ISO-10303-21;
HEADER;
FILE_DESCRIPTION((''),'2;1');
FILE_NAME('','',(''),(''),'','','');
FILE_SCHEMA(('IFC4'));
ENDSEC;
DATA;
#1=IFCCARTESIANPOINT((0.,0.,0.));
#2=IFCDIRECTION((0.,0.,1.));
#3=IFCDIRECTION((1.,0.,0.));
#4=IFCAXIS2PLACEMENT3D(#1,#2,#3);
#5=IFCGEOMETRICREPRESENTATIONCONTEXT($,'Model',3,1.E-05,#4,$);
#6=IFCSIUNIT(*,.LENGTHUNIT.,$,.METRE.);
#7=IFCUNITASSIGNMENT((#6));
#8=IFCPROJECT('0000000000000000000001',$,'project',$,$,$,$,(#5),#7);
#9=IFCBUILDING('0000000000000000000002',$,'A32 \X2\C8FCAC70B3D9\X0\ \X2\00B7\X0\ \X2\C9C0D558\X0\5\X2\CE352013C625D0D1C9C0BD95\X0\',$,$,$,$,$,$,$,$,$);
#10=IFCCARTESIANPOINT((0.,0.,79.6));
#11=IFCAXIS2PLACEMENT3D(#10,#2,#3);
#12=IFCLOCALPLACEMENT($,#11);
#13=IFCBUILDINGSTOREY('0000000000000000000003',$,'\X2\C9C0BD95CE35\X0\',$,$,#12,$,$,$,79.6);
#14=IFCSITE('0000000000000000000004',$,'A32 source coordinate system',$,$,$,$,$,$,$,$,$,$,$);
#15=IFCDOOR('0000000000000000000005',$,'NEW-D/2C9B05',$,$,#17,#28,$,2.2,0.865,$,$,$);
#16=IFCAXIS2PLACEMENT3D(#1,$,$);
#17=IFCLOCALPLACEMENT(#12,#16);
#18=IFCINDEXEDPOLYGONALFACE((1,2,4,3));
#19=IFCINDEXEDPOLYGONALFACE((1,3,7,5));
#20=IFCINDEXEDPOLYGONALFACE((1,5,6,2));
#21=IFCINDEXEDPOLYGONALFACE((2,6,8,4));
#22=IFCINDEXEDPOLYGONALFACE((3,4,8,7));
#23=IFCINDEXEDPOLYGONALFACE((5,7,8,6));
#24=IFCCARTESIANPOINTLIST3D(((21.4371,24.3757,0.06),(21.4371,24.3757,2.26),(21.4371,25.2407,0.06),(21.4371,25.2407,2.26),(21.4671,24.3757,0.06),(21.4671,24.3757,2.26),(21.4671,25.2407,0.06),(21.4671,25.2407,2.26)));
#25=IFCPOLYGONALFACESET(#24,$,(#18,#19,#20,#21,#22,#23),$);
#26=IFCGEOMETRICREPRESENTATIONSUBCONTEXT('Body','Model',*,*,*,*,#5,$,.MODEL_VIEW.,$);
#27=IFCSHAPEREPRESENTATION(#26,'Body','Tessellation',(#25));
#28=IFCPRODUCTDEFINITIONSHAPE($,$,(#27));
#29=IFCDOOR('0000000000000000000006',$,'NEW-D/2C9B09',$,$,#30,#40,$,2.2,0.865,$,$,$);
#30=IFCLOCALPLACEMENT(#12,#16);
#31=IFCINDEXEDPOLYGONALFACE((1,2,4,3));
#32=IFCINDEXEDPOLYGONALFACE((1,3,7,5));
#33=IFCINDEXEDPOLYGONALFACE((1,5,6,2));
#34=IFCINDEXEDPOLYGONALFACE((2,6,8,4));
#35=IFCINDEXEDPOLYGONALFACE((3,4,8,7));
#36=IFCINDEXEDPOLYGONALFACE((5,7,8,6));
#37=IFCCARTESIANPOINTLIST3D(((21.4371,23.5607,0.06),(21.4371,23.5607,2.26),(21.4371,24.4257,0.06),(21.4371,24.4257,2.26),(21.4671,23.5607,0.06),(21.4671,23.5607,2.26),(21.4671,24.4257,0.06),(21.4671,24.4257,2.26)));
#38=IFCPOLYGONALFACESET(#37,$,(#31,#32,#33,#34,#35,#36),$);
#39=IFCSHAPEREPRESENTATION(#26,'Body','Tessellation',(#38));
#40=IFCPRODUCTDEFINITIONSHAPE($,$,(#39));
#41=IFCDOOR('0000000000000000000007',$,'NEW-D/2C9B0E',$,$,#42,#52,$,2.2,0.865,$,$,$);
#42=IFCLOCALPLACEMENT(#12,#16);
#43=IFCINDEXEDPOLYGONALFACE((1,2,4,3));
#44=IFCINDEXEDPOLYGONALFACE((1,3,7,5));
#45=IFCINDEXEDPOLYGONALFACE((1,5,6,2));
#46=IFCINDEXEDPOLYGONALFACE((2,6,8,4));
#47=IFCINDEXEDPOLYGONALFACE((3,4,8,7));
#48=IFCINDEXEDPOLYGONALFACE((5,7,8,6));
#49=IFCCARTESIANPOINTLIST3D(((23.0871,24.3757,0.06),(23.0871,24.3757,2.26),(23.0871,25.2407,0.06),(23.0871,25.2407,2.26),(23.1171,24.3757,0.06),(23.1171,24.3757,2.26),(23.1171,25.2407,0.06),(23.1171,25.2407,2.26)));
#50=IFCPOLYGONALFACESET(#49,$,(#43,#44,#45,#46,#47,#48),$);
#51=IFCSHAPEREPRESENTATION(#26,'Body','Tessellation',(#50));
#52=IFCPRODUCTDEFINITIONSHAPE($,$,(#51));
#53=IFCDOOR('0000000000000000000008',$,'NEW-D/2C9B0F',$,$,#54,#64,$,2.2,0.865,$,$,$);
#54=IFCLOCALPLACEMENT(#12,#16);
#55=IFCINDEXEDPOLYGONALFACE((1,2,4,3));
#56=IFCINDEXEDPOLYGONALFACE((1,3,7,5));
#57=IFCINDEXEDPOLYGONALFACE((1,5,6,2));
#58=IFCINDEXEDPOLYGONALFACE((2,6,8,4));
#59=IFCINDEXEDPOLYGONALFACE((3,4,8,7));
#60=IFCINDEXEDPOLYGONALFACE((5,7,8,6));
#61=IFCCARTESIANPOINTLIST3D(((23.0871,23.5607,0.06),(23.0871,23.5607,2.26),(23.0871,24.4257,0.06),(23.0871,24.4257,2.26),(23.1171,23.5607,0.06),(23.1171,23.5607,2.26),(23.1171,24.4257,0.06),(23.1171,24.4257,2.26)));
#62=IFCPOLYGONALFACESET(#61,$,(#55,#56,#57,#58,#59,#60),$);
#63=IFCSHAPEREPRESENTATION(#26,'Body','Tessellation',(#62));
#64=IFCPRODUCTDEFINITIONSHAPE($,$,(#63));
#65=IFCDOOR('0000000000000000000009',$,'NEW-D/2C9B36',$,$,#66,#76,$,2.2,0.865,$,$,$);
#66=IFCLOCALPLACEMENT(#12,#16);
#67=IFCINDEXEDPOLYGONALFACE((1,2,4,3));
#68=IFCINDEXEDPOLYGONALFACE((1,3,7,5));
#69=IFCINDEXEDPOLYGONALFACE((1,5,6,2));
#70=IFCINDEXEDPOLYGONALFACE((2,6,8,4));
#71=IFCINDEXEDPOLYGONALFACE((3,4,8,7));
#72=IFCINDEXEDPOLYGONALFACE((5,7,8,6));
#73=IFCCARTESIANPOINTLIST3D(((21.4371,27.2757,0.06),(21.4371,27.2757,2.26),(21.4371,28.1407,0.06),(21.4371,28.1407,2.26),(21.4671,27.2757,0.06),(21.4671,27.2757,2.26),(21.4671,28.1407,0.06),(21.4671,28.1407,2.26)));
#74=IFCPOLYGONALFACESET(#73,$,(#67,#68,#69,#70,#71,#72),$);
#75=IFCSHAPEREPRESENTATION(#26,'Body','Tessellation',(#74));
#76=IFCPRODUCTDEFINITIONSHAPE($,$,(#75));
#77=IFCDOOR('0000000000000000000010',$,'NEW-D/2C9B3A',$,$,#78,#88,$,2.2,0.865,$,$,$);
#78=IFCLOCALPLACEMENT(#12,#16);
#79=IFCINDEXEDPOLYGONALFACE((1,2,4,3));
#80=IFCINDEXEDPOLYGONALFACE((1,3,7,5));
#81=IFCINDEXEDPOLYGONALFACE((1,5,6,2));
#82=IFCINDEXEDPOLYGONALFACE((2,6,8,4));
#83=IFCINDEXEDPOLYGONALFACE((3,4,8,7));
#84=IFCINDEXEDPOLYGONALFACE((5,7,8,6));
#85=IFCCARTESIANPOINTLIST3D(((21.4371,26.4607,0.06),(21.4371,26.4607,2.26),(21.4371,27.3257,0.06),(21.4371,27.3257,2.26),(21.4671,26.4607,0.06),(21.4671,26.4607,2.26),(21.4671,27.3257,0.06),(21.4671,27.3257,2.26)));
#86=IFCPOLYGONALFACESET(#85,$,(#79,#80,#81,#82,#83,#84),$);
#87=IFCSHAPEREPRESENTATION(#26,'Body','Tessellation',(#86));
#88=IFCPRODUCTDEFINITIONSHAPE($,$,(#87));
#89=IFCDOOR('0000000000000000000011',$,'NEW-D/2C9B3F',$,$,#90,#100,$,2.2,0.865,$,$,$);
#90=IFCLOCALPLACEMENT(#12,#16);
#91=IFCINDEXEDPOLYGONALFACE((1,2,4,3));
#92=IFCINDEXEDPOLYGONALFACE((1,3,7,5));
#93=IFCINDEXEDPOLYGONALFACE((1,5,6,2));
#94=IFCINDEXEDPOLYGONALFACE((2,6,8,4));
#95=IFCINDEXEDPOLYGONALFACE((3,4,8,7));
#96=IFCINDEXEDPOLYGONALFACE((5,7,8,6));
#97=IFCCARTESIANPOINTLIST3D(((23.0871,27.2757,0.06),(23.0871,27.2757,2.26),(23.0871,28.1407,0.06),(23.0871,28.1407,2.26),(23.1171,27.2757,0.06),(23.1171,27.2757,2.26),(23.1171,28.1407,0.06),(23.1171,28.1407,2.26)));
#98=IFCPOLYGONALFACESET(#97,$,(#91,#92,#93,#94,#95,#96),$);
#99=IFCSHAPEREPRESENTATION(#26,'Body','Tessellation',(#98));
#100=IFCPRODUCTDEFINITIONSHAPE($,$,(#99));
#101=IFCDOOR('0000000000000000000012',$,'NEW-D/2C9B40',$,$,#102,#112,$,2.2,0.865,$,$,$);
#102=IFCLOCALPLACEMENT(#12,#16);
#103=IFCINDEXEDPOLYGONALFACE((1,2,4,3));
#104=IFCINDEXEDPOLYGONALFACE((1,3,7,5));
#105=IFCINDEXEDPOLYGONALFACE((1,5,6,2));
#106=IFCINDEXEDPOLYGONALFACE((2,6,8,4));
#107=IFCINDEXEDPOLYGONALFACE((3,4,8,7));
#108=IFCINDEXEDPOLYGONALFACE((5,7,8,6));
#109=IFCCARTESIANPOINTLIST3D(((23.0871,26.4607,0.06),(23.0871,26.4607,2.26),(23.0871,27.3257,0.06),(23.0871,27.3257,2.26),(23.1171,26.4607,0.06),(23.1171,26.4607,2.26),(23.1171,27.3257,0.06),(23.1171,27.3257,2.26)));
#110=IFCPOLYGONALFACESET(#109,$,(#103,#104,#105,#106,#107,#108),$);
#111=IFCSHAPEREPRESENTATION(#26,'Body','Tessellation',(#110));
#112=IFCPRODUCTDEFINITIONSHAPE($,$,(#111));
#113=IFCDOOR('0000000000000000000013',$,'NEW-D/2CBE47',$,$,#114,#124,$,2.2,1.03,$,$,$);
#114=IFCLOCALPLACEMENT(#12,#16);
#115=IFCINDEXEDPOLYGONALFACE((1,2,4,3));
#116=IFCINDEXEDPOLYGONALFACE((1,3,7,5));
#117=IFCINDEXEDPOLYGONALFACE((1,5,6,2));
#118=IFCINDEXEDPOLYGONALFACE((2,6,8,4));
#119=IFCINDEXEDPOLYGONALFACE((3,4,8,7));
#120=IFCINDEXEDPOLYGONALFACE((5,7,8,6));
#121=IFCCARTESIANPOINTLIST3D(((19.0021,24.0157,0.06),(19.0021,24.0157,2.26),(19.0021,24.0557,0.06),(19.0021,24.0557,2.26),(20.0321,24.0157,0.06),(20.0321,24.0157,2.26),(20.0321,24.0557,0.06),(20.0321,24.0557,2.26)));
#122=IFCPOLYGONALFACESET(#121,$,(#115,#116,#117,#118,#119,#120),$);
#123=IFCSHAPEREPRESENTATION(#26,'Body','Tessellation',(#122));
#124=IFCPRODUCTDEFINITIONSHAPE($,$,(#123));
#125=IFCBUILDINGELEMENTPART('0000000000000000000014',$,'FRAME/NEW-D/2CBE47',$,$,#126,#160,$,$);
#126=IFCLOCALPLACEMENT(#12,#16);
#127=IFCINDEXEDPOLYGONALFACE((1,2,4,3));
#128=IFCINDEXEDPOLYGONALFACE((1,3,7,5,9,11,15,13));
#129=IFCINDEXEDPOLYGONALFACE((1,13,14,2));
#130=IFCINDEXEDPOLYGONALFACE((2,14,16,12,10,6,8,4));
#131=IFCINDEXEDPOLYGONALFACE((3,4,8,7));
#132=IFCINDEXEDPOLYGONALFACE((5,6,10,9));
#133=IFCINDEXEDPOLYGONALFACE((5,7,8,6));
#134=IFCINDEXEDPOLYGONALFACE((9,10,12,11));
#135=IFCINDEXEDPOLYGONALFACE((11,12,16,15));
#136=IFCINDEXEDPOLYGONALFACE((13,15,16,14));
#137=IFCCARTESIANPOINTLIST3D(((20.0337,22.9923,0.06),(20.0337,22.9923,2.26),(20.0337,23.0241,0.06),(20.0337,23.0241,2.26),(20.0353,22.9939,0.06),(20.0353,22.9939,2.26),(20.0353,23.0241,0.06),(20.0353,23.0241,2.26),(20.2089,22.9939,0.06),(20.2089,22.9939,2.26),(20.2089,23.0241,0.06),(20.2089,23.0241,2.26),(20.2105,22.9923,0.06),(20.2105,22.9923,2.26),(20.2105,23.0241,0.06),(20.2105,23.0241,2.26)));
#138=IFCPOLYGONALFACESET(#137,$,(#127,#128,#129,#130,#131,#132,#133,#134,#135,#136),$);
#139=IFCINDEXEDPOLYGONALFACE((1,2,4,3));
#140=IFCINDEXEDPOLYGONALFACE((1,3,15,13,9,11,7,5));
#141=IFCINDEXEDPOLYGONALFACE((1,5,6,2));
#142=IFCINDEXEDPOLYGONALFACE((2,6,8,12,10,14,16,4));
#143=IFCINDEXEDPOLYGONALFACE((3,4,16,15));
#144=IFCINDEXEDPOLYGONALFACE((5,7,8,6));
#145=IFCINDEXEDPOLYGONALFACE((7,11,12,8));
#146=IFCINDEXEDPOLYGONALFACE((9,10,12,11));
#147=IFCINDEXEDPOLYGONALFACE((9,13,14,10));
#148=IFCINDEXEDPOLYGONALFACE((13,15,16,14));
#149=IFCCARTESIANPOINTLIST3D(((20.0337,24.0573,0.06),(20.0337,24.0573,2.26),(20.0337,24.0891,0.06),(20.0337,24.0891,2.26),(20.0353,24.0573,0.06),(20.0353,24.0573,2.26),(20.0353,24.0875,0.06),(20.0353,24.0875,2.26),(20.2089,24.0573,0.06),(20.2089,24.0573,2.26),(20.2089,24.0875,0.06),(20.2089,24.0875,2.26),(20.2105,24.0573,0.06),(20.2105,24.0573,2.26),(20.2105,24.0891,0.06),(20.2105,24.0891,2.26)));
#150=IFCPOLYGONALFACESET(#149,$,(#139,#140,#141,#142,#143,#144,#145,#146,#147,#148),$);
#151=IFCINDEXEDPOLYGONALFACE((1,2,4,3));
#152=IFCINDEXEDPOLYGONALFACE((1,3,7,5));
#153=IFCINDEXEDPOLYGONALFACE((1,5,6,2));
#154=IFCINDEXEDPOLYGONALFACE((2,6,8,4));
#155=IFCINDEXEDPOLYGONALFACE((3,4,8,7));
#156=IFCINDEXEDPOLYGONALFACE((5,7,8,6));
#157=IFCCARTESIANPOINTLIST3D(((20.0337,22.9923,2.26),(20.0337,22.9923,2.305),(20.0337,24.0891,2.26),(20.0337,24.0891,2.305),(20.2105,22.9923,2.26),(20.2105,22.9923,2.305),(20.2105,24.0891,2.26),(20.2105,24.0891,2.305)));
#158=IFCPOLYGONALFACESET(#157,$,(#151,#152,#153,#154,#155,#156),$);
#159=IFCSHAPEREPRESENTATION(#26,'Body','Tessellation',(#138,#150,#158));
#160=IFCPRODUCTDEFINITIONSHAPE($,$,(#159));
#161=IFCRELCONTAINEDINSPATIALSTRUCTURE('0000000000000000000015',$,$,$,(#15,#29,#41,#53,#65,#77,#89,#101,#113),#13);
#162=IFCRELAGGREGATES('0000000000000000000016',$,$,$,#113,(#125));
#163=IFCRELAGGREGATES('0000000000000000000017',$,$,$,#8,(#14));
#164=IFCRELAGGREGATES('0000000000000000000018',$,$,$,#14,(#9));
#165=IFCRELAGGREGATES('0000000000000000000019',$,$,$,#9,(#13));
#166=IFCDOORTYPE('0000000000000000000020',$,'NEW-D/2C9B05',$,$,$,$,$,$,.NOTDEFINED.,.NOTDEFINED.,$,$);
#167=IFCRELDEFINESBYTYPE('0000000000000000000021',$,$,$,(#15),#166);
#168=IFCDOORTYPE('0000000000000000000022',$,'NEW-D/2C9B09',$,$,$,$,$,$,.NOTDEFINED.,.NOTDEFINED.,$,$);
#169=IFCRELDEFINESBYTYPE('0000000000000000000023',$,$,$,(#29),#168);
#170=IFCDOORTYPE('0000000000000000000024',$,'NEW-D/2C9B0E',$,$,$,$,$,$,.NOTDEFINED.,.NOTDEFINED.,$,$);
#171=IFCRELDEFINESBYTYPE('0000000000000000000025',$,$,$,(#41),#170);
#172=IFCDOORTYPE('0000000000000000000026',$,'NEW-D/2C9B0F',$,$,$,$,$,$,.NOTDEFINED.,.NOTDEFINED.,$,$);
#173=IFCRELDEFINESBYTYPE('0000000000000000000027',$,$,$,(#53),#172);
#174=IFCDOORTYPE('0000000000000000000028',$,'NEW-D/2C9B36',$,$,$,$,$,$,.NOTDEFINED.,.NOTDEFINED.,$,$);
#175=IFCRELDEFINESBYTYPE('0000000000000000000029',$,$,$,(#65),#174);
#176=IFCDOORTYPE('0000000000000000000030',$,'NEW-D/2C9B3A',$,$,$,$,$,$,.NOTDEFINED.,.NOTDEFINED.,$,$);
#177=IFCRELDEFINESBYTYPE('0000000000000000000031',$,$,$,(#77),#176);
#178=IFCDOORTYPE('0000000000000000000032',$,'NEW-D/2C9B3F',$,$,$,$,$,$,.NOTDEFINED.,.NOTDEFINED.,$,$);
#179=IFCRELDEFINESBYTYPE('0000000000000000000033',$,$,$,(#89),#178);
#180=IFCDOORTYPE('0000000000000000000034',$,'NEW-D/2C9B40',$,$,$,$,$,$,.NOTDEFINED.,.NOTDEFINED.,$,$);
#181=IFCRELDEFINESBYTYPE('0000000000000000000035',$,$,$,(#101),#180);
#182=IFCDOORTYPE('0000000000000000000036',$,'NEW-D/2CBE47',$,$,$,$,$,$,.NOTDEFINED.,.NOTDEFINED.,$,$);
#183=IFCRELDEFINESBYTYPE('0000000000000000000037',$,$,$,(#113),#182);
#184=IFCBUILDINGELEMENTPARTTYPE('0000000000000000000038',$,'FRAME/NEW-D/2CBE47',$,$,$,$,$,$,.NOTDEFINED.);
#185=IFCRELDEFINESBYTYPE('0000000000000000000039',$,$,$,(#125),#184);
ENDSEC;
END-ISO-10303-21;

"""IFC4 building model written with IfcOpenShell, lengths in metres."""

from ifc_helpers import new_model, si_unit, frame, origin, origin_with_axes, place, context, subcontext, project, spatial, polyline, outline, extrude, source, transform, mapped, type_object, type_shapes, element, aggregate, save


model = new_model("IFC4")

# Units and contexts
model_context = context("Model", 3, precision=1e-05, world=origin_with_axes())
body_context = subcontext(model_context, "Body", "Model", "MODEL_VIEW")
ifc_project = project(units=[si_unit("LENGTHUNIT", "METRE")], contexts=[model_context])

# Site, building, storey
site = spatial("IfcSite", under=ifc_project, Name="A32 source coordinate system")
building = spatial("IfcBuilding", under=site, Name="A32 주거동 · 지하5층–옥탑지붕")
storey_placement = place(None, frame((0.0, 0.0, 79.6), z_axis=(0.0, 0.0, 1.0), x_axis=(1.0, 0.0, 0.0)))
storey = spatial("IfcBuildingStorey", under=building, at=storey_placement, Name="지붕층", Elevation=79.6)

# Doors
door_type_1 = type_object("IfcDoorType", Name="NEW-D/2C9B05", OperationType="NOTDEFINED", PredefinedType="NOTDEFINED")
shared_shape_1 = source(origin(), body_context, "Body", "SweptSolid", [
    extrude(outline(polyline([(21.4371, 25.2407), (21.4671, 25.2407), (21.4671, 24.3757), (21.4371, 24.3757), (21.4371, 25.2407)])), frame((0.0, 0.0, 0.06)), (0.0, 0.0, 1.0), 2.2),
])
type_shapes(door_type_1, [shared_shape_1])
door_1_placement = place(storey_placement, origin_with_axes())
element("IfcDoor", 1, at=door_1_placement, inside=storey, type_object=door_type_1, Name="NEW-D/2C9B05", OverallHeight=2.2, OverallWidth=0.865, context=body_context, shape_type="MappedRepresentation", body=[
    mapped(shared_shape_1, transform((0.0, 0.0, 0.0), scale=1.0)),
])
door_type_2 = type_object("IfcDoorType", Name="NEW-D/2C9B09", OperationType="NOTDEFINED", PredefinedType="NOTDEFINED")
shared_shape_2 = source(origin(), body_context, "Body", "SweptSolid", [
    extrude(outline(polyline([(21.4671, 24.4257), (21.4671, 23.5607), (21.4371, 23.5607), (21.4371, 24.4257), (21.4671, 24.4257)])), frame((0.0, 0.0, 0.06)), (0.0, 0.0, 1.0), 2.2),
])
type_shapes(door_type_2, [shared_shape_2])
door_2_placement = place(storey_placement, origin_with_axes())
element("IfcDoor", 2, at=door_2_placement, inside=storey, type_object=door_type_2, Name="NEW-D/2C9B09", OverallHeight=2.2, OverallWidth=0.865, context=body_context, shape_type="MappedRepresentation", body=[
    mapped(shared_shape_2, transform((0.0, 0.0, 0.0), scale=1.0)),
])
door_type_3 = type_object("IfcDoorType", Name="NEW-D/2C9B0E", OperationType="NOTDEFINED", PredefinedType="NOTDEFINED")
shared_shape_3 = source(origin(), body_context, "Body", "SweptSolid", [
    extrude(outline(polyline([(23.0871, 24.3757), (23.0871, 25.2407), (23.1171, 25.2407), (23.1171, 24.3757), (23.0871, 24.3757)])), frame((0.0, 0.0, 0.06)), (0.0, 0.0, 1.0), 2.2),
])
type_shapes(door_type_3, [shared_shape_3])
door_3_placement = place(storey_placement, origin_with_axes())
element("IfcDoor", 3, at=door_3_placement, inside=storey, type_object=door_type_3, Name="NEW-D/2C9B0E", OverallHeight=2.2, OverallWidth=0.865, context=body_context, shape_type="MappedRepresentation", body=[
    mapped(shared_shape_3, transform((0.0, 0.0, 0.0), scale=1.0)),
])
door_type_4 = type_object("IfcDoorType", Name="NEW-D/2C9B0F", OperationType="NOTDEFINED", PredefinedType="NOTDEFINED")
shared_shape_4 = source(origin(), body_context, "Body", "SweptSolid", [
    extrude(outline(polyline([(23.1171, 23.5607), (23.0871, 23.5607), (23.0871, 24.4257), (23.1171, 24.4257), (23.1171, 23.5607)])), frame((0.0, 0.0, 0.06)), (0.0, 0.0, 1.0), 2.2),
])
type_shapes(door_type_4, [shared_shape_4])
door_4_placement = place(storey_placement, origin_with_axes())
element("IfcDoor", 4, at=door_4_placement, inside=storey, type_object=door_type_4, Name="NEW-D/2C9B0F", OverallHeight=2.2, OverallWidth=0.865, context=body_context, shape_type="MappedRepresentation", body=[
    mapped(shared_shape_4, transform((0.0, 0.0, 0.0), scale=1.0)),
])
door_type_5 = type_object("IfcDoorType", Name="NEW-D/2C9B36", OperationType="NOTDEFINED", PredefinedType="NOTDEFINED")
shared_shape_5 = source(origin(), body_context, "Body", "SweptSolid", [
    extrude(outline(polyline([(21.4371, 28.1407), (21.4671, 28.1407), (21.4671, 27.2757), (21.4371, 27.2757), (21.4371, 28.1407)])), frame((0.0, 0.0, 0.06)), (0.0, 0.0, 1.0), 2.2),
])
type_shapes(door_type_5, [shared_shape_5])
door_5_placement = place(storey_placement, origin_with_axes())
element("IfcDoor", 5, at=door_5_placement, inside=storey, type_object=door_type_5, Name="NEW-D/2C9B36", OverallHeight=2.2, OverallWidth=0.865, context=body_context, shape_type="MappedRepresentation", body=[
    mapped(shared_shape_5, transform((0.0, 0.0, 0.0), scale=1.0)),
])
door_type_6 = type_object("IfcDoorType", Name="NEW-D/2C9B3A", OperationType="NOTDEFINED", PredefinedType="NOTDEFINED")
shared_shape_6 = source(origin(), body_context, "Body", "SweptSolid", [
    extrude(outline(polyline([(21.4671, 27.3257), (21.4671, 26.4607), (21.4371, 26.4607), (21.4371, 27.3257), (21.4671, 27.3257)])), frame((0.0, 0.0, 0.06)), (0.0, 0.0, 1.0), 2.2),
])
type_shapes(door_type_6, [shared_shape_6])
door_6_placement = place(storey_placement, origin_with_axes())
element("IfcDoor", 6, at=door_6_placement, inside=storey, type_object=door_type_6, Name="NEW-D/2C9B3A", OverallHeight=2.2, OverallWidth=0.865, context=body_context, shape_type="MappedRepresentation", body=[
    mapped(shared_shape_6, transform((0.0, 0.0, 0.0), scale=1.0)),
])
door_type_7 = type_object("IfcDoorType", Name="NEW-D/2C9B3F", OperationType="NOTDEFINED", PredefinedType="NOTDEFINED")
shared_shape_7 = source(origin(), body_context, "Body", "SweptSolid", [
    extrude(outline(polyline([(23.0871, 27.2757), (23.0871, 28.1407), (23.1171, 28.1407), (23.1171, 27.2757), (23.0871, 27.2757)])), frame((0.0, 0.0, 0.06)), (0.0, 0.0, 1.0), 2.2),
])
type_shapes(door_type_7, [shared_shape_7])
door_7_placement = place(storey_placement, origin_with_axes())
element("IfcDoor", 7, at=door_7_placement, inside=storey, type_object=door_type_7, Name="NEW-D/2C9B3F", OverallHeight=2.2, OverallWidth=0.865, context=body_context, shape_type="MappedRepresentation", body=[
    mapped(shared_shape_7, transform((0.0, 0.0, 0.0), scale=1.0)),
])
door_type_8 = type_object("IfcDoorType", Name="NEW-D/2C9B40", OperationType="NOTDEFINED", PredefinedType="NOTDEFINED")
shared_shape_8 = source(origin(), body_context, "Body", "SweptSolid", [
    extrude(outline(polyline([(23.1171, 26.4607), (23.0871, 26.4607), (23.0871, 27.3257), (23.1171, 27.3257), (23.1171, 26.4607)])), frame((0.0, 0.0, 0.06)), (0.0, 0.0, 1.0), 2.2),
])
type_shapes(door_type_8, [shared_shape_8])
door_8_placement = place(storey_placement, origin_with_axes())
element("IfcDoor", 8, at=door_8_placement, inside=storey, type_object=door_type_8, Name="NEW-D/2C9B40", OverallHeight=2.2, OverallWidth=0.865, context=body_context, shape_type="MappedRepresentation", body=[
    mapped(shared_shape_8, transform((0.0, 0.0, 0.0), scale=1.0)),
])

# Door
door_type_9 = type_object("IfcDoorType", Name="NEW-D/2CBE47", OperationType="NOTDEFINED", PredefinedType="NOTDEFINED")
shared_shape_9 = source(origin(), body_context, "Body", "SweptSolid", [
    extrude(outline(polyline([(20.0321, 24.0557), (20.0321, 24.0157), (19.0021, 24.0157), (19.0021, 24.0557), (20.0321, 24.0557)])), frame((0.0, 0.0, 0.06)), (0.0, 0.0, 1.0), 2.2),
])
type_shapes(door_type_9, [shared_shape_9])
door_9_placement = place(storey_placement, origin_with_axes())
door_9 = element("IfcDoor", 9, at=door_9_placement, inside=storey, type_object=door_type_9, Name="NEW-D/2CBE47", OverallHeight=2.2, OverallWidth=1.03, context=body_context, shape_type="MappedRepresentation", body=[
    mapped(shared_shape_9, transform((0.0, 0.0, 0.0), scale=1.0)),
])

# Building element part
building_element_part_type_1 = type_object("IfcBuildingElementPartType", Name="FRAME/NEW-D/2CBE47", PredefinedType="NOTDEFINED")
shared_shape_10 = source(origin(), body_context, "Body", "SweptSolid", [
    extrude(outline(polyline([(20.0353, 22.9939), (20.2089, 22.9939), (20.2089, 23.0241), (20.2105, 23.0241), (20.2105, 22.9923), (20.0337, 22.9923), (20.0337, 23.0241), (20.0353, 23.0241), (20.0353, 22.9939)])), frame((0.0, 0.0, 0.06)), (0.0, 0.0, 1.0), 2.2),
    extrude(outline(polyline([(20.2105, 24.0891), (20.2105, 24.0573), (20.2089, 24.0573), (20.2089, 24.0875), (20.0353, 24.0875), (20.0353, 24.0573), (20.0337, 24.0573), (20.0337, 24.0891), (20.2105, 24.0891)])), frame((0.0, 0.0, 0.06)), (0.0, 0.0, 1.0), 2.2),
    extrude(outline(polyline([(20.2105, 22.9923), (20.2105, 24.0891), (20.0337, 24.0891), (20.0337, 22.9923), (20.2105, 22.9923)])), frame((0.0, 0.0, 2.26)), (0.0, 0.0, 1.0), 0.045),
])
type_shapes(building_element_part_type_1, [shared_shape_10])
building_element_part_1_placement = place(door_9_placement, origin_with_axes())
building_element_part_1 = element("IfcBuildingElementPart", 10, at=building_element_part_1_placement, type_object=building_element_part_type_1, Name="FRAME/NEW-D/2CBE47", context=body_context, shape_type="MappedRepresentation", body=[
    mapped(shared_shape_10, transform((0.0, 0.0, 0.0), scale=1.0)),
])
aggregate(door_9, [building_element_part_1])

save(model, "model.ifc")
